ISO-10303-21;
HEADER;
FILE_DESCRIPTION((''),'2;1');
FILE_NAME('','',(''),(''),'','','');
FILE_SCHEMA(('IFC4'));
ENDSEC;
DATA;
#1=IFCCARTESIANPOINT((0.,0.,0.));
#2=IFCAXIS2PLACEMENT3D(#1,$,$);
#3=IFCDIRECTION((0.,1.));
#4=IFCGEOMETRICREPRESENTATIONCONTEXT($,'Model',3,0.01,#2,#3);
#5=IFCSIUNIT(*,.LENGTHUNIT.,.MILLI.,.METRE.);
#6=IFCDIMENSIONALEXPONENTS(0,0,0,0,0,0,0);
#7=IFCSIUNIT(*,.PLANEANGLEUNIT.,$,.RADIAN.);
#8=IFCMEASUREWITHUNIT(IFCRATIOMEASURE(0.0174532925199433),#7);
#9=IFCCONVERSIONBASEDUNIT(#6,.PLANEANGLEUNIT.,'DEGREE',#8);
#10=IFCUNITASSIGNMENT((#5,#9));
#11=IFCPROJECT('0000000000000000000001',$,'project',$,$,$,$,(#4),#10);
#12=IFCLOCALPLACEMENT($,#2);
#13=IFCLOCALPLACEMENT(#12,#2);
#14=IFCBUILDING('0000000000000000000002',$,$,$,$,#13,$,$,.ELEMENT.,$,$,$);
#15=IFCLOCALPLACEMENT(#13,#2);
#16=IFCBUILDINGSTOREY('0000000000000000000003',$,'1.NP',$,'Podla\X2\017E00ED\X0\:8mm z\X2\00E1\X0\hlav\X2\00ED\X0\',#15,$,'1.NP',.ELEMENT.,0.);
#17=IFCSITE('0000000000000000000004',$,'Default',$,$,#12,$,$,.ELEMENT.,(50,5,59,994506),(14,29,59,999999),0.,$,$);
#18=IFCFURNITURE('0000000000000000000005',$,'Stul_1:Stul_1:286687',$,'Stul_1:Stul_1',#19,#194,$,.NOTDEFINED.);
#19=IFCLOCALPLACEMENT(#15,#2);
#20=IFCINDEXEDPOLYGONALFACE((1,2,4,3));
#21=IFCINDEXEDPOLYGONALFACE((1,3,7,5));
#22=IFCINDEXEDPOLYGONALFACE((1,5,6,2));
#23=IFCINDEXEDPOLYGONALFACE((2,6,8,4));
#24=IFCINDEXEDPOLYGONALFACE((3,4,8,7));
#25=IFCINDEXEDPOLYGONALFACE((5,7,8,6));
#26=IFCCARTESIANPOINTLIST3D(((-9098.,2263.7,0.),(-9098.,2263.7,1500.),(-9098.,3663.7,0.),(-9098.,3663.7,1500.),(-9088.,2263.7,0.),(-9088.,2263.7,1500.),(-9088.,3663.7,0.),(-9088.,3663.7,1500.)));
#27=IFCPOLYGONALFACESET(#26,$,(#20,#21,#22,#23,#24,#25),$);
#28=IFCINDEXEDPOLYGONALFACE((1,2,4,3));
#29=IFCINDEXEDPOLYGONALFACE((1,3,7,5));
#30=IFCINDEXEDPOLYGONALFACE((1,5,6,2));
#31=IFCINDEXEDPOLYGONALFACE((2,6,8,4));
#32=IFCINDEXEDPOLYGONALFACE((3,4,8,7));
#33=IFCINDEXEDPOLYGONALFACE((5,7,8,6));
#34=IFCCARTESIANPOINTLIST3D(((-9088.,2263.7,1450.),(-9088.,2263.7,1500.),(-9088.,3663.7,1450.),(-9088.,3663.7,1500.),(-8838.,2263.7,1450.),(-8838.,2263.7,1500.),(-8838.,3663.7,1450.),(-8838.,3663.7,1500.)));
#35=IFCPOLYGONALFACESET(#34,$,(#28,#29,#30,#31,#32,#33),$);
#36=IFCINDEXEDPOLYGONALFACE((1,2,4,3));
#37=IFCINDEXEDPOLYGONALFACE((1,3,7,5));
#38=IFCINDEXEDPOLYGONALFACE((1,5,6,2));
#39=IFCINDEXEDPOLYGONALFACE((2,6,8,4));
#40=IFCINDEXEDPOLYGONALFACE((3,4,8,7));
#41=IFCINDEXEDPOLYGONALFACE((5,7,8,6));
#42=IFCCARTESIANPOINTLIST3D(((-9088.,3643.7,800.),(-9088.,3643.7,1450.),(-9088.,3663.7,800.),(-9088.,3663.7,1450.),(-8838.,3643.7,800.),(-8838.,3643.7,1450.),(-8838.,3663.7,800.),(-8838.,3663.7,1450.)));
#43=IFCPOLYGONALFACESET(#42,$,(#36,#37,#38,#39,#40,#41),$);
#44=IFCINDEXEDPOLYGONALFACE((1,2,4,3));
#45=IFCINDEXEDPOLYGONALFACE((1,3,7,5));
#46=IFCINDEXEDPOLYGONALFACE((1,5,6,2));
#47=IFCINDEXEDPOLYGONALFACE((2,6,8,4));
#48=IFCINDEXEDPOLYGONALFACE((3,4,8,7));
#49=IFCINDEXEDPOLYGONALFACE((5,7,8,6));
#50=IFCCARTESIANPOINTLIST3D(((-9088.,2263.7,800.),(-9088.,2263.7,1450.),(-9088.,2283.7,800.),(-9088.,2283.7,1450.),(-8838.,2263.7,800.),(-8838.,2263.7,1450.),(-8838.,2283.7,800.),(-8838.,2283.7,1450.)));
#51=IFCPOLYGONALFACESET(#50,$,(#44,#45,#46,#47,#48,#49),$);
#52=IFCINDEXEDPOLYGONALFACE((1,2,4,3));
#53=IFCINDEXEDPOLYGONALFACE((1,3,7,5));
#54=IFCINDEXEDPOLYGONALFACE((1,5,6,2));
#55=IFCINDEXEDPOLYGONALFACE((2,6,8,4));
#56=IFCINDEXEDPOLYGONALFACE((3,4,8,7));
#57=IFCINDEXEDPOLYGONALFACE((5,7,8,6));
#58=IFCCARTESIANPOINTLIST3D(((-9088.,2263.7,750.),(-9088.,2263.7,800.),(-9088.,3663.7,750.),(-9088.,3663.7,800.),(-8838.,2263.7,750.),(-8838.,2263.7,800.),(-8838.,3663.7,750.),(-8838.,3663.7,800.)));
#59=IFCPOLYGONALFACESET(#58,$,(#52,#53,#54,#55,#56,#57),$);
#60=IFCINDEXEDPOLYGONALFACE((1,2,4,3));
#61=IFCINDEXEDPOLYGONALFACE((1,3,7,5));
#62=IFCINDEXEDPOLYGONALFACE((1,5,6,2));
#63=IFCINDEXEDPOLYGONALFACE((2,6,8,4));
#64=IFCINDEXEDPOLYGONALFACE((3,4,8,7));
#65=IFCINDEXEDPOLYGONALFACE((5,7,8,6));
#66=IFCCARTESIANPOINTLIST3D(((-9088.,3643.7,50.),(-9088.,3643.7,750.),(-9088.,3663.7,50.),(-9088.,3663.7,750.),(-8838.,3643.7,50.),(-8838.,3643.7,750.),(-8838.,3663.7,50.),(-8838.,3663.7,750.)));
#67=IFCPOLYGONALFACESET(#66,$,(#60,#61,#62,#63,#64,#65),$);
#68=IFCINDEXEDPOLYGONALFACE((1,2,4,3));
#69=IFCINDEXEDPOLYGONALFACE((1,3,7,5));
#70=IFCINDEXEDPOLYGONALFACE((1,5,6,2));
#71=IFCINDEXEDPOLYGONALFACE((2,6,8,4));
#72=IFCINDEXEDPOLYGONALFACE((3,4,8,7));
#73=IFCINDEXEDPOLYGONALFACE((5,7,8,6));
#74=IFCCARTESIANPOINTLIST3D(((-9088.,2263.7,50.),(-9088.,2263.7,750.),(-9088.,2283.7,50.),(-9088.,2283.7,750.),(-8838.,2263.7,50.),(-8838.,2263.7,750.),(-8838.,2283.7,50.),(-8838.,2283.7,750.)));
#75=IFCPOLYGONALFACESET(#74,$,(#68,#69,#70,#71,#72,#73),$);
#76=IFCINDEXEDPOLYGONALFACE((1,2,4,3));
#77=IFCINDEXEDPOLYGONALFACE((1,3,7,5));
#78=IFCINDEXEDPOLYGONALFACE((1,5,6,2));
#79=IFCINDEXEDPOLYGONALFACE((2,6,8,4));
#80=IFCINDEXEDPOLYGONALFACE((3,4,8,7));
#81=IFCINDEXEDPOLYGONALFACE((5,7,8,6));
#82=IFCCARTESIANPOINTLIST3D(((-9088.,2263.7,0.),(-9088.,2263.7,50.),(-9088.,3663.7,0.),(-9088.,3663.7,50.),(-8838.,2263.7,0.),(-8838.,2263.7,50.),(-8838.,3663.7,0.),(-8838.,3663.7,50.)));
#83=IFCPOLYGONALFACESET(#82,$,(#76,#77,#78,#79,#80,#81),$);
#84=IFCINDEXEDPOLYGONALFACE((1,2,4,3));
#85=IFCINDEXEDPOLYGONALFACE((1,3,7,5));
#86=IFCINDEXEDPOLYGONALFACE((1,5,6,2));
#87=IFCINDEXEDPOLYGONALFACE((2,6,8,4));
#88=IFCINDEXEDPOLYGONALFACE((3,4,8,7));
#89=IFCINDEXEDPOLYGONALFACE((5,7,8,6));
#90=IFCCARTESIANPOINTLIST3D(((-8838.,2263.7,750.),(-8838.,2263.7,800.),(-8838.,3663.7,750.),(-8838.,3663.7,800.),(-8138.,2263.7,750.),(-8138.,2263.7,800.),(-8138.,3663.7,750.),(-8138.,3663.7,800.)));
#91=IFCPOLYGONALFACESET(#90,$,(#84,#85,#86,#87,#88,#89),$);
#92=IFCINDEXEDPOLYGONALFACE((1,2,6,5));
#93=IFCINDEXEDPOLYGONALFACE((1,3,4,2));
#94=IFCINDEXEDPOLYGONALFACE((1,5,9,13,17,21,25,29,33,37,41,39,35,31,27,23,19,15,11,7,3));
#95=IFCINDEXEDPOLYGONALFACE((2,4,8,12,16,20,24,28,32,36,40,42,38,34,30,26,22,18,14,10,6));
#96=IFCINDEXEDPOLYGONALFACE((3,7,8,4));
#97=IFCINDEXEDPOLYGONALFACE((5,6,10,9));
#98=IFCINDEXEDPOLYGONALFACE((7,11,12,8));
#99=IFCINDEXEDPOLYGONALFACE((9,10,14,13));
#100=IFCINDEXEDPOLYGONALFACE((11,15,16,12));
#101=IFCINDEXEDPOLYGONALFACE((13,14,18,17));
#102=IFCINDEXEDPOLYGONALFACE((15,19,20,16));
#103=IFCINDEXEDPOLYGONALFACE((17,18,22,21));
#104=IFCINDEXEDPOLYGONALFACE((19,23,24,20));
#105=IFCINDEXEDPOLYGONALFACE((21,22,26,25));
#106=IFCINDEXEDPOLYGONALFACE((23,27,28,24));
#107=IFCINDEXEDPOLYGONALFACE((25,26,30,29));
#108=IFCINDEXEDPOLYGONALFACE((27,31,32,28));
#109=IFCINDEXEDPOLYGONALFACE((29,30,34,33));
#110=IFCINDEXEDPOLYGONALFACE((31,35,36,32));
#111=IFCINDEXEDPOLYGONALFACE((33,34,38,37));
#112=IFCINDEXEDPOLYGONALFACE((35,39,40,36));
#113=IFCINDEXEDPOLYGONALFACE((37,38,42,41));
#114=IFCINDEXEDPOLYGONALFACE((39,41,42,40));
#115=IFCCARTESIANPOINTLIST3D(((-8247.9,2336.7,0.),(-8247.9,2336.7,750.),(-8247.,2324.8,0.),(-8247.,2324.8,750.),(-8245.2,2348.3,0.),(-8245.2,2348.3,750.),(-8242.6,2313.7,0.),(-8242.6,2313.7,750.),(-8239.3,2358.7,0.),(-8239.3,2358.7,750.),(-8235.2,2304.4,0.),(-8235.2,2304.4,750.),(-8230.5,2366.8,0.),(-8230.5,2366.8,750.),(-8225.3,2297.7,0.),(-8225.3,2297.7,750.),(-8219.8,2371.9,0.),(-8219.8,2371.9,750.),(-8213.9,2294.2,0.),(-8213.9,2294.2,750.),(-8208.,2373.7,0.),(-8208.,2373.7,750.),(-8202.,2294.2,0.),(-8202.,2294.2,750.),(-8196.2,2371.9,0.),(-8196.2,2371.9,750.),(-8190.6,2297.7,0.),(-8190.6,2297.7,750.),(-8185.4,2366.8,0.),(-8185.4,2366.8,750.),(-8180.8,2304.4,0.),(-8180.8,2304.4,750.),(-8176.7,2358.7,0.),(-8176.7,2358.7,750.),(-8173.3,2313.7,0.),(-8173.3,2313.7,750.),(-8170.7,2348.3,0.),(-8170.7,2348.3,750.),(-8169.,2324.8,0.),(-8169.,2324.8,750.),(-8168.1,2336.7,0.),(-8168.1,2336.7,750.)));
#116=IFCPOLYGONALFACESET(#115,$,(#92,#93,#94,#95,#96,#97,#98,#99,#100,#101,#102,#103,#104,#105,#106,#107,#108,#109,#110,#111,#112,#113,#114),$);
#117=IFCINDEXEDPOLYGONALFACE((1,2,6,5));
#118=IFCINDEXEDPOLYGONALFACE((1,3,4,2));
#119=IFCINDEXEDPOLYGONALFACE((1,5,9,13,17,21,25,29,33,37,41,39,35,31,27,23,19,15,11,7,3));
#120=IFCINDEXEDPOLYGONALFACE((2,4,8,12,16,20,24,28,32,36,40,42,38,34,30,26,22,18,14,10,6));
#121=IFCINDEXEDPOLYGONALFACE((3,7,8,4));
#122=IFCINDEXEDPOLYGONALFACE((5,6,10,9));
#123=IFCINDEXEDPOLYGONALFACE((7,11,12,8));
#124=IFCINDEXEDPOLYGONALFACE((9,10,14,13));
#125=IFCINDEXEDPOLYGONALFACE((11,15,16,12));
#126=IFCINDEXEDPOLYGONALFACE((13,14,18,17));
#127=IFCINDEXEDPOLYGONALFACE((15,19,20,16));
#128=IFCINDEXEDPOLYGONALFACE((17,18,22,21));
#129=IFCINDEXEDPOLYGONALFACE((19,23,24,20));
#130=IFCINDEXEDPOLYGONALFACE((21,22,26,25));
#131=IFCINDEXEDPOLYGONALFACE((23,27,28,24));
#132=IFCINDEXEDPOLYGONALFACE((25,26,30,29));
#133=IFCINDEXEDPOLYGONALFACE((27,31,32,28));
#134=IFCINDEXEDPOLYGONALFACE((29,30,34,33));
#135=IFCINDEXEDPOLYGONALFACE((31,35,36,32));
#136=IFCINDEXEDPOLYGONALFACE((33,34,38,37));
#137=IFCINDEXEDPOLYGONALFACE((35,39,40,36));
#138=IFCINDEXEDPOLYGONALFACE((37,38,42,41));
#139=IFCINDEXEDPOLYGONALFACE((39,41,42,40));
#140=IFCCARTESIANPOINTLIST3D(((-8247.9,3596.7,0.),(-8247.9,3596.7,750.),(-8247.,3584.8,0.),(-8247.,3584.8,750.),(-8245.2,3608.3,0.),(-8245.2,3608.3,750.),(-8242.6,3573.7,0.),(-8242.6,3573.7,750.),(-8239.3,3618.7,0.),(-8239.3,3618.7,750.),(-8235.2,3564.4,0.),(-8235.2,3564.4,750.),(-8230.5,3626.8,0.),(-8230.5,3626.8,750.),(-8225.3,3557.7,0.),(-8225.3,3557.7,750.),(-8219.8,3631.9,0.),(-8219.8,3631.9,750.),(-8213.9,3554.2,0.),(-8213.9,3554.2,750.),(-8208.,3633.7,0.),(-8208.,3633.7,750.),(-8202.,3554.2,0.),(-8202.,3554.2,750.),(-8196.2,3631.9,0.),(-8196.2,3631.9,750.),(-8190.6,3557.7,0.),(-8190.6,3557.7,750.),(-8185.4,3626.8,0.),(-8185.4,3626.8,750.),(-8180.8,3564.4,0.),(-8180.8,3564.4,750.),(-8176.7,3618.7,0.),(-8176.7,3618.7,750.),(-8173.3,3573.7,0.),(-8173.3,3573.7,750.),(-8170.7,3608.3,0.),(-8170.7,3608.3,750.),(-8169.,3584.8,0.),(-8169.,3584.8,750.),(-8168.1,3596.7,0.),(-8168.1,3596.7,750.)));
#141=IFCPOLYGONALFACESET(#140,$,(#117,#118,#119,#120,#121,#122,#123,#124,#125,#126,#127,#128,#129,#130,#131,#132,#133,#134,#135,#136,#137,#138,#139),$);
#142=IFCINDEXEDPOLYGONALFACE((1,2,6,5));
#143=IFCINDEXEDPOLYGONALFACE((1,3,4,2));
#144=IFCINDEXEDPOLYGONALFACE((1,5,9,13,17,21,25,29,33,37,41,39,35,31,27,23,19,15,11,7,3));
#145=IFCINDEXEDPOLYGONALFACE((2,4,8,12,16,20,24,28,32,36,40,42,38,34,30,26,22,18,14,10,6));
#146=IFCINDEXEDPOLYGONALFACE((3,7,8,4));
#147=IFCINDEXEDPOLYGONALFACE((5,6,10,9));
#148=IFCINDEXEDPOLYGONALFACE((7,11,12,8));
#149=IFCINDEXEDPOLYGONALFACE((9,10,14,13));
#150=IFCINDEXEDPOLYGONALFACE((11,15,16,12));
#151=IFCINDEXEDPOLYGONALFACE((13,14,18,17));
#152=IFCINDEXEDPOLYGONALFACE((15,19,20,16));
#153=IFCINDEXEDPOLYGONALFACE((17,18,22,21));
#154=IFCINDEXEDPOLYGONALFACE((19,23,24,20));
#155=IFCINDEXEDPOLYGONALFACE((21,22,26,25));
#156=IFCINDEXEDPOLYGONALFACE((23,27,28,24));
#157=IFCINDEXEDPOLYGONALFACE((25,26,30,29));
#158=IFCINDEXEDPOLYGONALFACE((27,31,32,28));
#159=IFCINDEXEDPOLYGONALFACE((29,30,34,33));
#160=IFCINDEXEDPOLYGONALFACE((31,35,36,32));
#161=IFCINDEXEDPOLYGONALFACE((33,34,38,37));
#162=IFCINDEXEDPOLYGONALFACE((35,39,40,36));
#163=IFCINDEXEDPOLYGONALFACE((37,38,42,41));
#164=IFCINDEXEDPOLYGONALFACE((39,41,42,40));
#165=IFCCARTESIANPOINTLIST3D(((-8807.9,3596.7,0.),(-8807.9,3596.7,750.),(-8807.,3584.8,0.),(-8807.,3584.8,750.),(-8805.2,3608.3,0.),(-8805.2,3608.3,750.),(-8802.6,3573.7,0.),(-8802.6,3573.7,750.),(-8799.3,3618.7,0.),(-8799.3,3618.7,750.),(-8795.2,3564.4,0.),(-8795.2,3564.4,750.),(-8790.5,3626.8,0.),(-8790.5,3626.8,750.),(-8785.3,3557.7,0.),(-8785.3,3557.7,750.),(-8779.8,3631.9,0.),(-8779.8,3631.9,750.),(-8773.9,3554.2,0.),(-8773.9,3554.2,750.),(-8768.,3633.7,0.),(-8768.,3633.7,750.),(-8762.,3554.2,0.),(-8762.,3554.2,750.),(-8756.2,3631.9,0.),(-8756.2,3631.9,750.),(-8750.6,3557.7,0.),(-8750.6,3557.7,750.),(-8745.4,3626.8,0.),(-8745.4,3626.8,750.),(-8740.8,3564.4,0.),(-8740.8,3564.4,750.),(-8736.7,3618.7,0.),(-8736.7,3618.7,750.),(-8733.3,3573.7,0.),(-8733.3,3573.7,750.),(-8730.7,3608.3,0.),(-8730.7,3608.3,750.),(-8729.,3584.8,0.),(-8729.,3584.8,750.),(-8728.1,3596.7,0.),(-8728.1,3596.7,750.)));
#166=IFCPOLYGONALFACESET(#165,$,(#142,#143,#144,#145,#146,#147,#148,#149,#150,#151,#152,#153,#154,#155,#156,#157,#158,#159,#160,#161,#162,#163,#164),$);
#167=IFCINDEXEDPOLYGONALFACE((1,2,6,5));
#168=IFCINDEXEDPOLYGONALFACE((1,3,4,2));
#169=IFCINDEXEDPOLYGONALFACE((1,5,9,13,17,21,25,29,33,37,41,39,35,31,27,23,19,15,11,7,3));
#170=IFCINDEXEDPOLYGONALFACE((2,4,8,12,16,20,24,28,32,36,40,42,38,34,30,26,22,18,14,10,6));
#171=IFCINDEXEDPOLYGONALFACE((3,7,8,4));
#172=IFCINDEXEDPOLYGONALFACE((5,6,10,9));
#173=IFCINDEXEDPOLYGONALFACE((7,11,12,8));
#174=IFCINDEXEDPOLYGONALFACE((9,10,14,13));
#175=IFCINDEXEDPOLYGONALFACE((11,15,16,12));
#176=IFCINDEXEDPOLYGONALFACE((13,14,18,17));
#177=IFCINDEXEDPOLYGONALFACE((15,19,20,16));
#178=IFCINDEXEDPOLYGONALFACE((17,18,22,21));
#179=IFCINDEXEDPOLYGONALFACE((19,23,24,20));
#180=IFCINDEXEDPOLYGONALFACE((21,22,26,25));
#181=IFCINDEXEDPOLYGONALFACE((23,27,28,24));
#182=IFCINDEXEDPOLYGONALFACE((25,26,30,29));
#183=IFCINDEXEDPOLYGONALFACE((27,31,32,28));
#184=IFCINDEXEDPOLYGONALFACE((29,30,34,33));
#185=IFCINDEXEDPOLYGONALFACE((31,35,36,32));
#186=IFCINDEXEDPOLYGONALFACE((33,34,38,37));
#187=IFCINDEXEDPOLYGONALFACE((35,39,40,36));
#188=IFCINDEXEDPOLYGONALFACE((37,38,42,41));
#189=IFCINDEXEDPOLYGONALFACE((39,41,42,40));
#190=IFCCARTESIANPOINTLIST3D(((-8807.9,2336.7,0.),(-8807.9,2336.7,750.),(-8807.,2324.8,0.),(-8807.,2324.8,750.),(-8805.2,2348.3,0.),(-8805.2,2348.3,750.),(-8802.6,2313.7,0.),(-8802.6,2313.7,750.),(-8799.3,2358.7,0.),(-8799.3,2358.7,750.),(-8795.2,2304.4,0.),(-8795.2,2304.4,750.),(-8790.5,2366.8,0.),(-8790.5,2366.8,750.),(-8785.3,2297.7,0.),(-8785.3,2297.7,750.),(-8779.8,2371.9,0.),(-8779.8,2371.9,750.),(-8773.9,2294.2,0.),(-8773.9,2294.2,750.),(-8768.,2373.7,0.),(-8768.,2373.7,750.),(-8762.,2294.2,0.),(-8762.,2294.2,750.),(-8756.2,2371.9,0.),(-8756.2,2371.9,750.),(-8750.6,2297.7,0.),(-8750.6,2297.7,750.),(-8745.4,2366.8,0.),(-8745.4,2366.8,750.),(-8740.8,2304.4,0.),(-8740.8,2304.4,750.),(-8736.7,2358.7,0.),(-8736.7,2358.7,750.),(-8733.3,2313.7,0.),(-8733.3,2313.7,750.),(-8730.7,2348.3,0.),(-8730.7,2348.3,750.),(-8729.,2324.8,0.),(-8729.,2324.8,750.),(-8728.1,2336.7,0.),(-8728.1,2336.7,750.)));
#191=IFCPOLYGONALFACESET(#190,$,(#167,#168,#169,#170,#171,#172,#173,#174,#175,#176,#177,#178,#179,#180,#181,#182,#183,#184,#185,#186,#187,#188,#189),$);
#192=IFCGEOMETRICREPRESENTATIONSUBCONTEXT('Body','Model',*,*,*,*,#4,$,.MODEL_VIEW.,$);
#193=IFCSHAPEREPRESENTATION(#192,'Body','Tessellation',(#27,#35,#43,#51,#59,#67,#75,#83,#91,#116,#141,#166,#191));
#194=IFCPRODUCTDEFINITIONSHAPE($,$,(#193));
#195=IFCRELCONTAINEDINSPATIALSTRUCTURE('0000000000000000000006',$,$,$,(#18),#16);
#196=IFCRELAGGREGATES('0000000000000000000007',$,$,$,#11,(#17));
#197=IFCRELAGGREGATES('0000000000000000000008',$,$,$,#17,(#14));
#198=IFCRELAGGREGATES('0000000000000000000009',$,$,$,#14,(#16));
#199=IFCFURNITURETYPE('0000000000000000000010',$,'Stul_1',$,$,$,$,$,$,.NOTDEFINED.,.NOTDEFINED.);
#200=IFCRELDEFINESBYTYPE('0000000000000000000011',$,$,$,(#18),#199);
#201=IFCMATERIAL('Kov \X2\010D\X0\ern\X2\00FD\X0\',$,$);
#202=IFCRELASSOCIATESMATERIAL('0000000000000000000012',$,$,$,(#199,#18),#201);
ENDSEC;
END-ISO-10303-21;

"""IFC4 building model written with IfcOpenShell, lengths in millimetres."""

from ifc_helpers import new_model, entity, si_unit, converted_unit, direction, frame, frame_2d, origin, origin_2d_with_axis, place, context, subcontext, project, spatial, rectangle, circle, extrude, source, transform, mapped, material, type_object, type_shapes, element, save


model = new_model("IFC4")

# Units and contexts
model_context = context("Model", 3, precision=0.01, world=origin(), true_north=direction((0.0, 1.0)))
body_context = subcontext(model_context, "Body", "Model", "MODEL_VIEW")
ifc_project = project(units=[si_unit("LENGTHUNIT", "METRE", prefix="MILLI"), converted_unit("PLANEANGLEUNIT", "DEGREE", entity("IfcRatioMeasure", 0.0174532925199433), si_unit("PLANEANGLEUNIT", "RADIAN"), dimensions=[0, 0, 0, 0, 0, 0, 0])], contexts=[model_context])

# Site, building, storey
site_placement = place(None, origin())
site = spatial("IfcSite", under=ifc_project, at=site_placement, Name="Default", CompositionType="ELEMENT", RefLatitude=(50, 5, 59, 994506), RefLongitude=(14, 29, 59, 999999), RefElevation=0.0)
building_placement = place(site_placement, origin())
building = spatial("IfcBuilding", under=site, at=building_placement, CompositionType="ELEMENT")
storey_placement = place(building_placement, origin())
storey = spatial("IfcBuildingStorey", under=building, at=storey_placement, Name="1.NP", ObjectType="Podlaží:8mm záhlaví", LongName="1.NP", CompositionType="ELEMENT", Elevation=0.0)

# Furniture
ifc_material_1 = material(Name="Kov černý")
furniture_type = type_object("IfcFurnitureType", Name="Stul_1", AssemblyPlace="NOTDEFINED", PredefinedType="NOTDEFINED", material=ifc_material_1)
shared_shape_1 = source(origin(), body_context, "Body", "SweptSolid", [
    extrude(rectangle(XDim=1400.0, YDim=10.0, at=origin_2d_with_axis()), frame((0.0, 605.0, 0.0), z_axis=(0.0, 0.0, 1.0), x_axis=(-1.0, 0.0, 0.0)), (0.0, 0.0, 1.0), 1500.0),
    extrude(rectangle(XDim=1400.0, YDim=250.0, at=frame_2d((0.0, 0.0), x_axis=(1.0, 0.0))), frame((0.0, 475.0, 1450.0), z_axis=(0.0, 0.0, 1.0), x_axis=(-1.0, 0.0, 0.0)), (0.0, 0.0, 1.0), 50.0),
    extrude(rectangle(XDim=20.0, YDim=250.0, at=origin_2d_with_axis()), frame((690.0, 475.0, 800.0), z_axis=(0.0, 0.0, 1.0), x_axis=(-1.0, 0.0, 0.0)), (0.0, 0.0, 1.0), 650.0),
    extrude(rectangle(XDim=20.0, YDim=250.0, at=frame_2d((0.0, 0.0), x_axis=(1.0, 0.0))), frame((-690.0, 475.0, 800.0), z_axis=(0.0, 0.0, 1.0), x_axis=(-1.0, 0.0, 0.0)), (0.0, 0.0, 1.0), 650.0),
    extrude(rectangle(XDim=1400.0, YDim=250.0, at=origin_2d_with_axis()), frame((0.0, 475.0, 750.0), z_axis=(0.0, 0.0, 1.0), x_axis=(-1.0, 0.0, 0.0)), (0.0, 0.0, 1.0), 50.0),
    extrude(rectangle(XDim=20.0, YDim=250.0, at=origin_2d_with_axis()), frame((690.0, 475.0, 50.0), z_axis=(0.0, 0.0, 1.0), x_axis=(-1.0, 0.0, 0.0)), (0.0, 0.0, 1.0), 700.0),
    extrude(rectangle(XDim=20.0, YDim=250.0, at=frame_2d((0.0, 0.0), x_axis=(1.0, 0.0))), frame((-690.0, 475.0, 50.0), z_axis=(0.0, 0.0, 1.0), x_axis=(-1.0, 0.0, 0.0)), (0.0, 0.0, 1.0), 700.0),
    extrude(rectangle(XDim=1400.0, YDim=250.0, at=origin_2d_with_axis()), frame((0.0, 475.0, 0.0), z_axis=(0.0, 0.0, 1.0), x_axis=(-1.0, 0.0, 0.0)), (0.0, 0.0, 1.0), 50.0),
    extrude(rectangle(XDim=1400.0, YDim=700.0, at=origin_2d_with_axis()), frame((0.0, 0.0, 750.0), z_axis=(0.0, 0.0, 1.0), x_axis=(-1.0, 0.0, 0.0)), (0.0, 0.0, 1.0), 50.0),
    extrude(circle(Radius=40.0, at=frame_2d((0.0, 0.0), x_axis=(1.0, 0.0))), frame((-630.0, -280.0, 0.0)), (0.0, 0.0, 1.0), 750.0),
    extrude(circle(Radius=40.0, at=frame_2d((0.0, 0.0), x_axis=(1.0, 0.0))), frame((630.0, -280.0, 0.0)), (0.0, 0.0, 1.0), 750.0),
    extrude(circle(Radius=40.0, at=frame_2d((0.0, 0.0), x_axis=(1.0, 0.0))), frame((630.0, 280.0, 0.0)), (0.0, 0.0, 1.0), 750.0),
    extrude(circle(Radius=40.0, at=frame_2d((0.0, 0.0), x_axis=(1.0, 0.0))), frame((-630.0, 280.0, 0.0)), (0.0, 0.0, 1.0), 750.0),
])
type_shapes(furniture_type, [shared_shape_1])
for number, where, z_axis, x_axis, name in (
    (1, (-8488.0, 2963.7, 0.0), (0.0, 0.0, 1.0), (0.0, 1.0, 0.0), "Stul_1:Stul_1:286687"),
):
    element("IfcFurniture", number, at=place(storey_placement, frame(where, z_axis=z_axis, x_axis=x_axis)), inside=storey, type_object=furniture_type, material=ifc_material_1, Name=name, ObjectType="Stul_1:Stul_1", PredefinedType="NOTDEFINED", context=body_context, shape_type="MappedRepresentation", body=[
        mapped(shared_shape_1, transform((0.0, 0.0, 0.0), scale=1.0)),
    ])

save(model, "model.ifc")
